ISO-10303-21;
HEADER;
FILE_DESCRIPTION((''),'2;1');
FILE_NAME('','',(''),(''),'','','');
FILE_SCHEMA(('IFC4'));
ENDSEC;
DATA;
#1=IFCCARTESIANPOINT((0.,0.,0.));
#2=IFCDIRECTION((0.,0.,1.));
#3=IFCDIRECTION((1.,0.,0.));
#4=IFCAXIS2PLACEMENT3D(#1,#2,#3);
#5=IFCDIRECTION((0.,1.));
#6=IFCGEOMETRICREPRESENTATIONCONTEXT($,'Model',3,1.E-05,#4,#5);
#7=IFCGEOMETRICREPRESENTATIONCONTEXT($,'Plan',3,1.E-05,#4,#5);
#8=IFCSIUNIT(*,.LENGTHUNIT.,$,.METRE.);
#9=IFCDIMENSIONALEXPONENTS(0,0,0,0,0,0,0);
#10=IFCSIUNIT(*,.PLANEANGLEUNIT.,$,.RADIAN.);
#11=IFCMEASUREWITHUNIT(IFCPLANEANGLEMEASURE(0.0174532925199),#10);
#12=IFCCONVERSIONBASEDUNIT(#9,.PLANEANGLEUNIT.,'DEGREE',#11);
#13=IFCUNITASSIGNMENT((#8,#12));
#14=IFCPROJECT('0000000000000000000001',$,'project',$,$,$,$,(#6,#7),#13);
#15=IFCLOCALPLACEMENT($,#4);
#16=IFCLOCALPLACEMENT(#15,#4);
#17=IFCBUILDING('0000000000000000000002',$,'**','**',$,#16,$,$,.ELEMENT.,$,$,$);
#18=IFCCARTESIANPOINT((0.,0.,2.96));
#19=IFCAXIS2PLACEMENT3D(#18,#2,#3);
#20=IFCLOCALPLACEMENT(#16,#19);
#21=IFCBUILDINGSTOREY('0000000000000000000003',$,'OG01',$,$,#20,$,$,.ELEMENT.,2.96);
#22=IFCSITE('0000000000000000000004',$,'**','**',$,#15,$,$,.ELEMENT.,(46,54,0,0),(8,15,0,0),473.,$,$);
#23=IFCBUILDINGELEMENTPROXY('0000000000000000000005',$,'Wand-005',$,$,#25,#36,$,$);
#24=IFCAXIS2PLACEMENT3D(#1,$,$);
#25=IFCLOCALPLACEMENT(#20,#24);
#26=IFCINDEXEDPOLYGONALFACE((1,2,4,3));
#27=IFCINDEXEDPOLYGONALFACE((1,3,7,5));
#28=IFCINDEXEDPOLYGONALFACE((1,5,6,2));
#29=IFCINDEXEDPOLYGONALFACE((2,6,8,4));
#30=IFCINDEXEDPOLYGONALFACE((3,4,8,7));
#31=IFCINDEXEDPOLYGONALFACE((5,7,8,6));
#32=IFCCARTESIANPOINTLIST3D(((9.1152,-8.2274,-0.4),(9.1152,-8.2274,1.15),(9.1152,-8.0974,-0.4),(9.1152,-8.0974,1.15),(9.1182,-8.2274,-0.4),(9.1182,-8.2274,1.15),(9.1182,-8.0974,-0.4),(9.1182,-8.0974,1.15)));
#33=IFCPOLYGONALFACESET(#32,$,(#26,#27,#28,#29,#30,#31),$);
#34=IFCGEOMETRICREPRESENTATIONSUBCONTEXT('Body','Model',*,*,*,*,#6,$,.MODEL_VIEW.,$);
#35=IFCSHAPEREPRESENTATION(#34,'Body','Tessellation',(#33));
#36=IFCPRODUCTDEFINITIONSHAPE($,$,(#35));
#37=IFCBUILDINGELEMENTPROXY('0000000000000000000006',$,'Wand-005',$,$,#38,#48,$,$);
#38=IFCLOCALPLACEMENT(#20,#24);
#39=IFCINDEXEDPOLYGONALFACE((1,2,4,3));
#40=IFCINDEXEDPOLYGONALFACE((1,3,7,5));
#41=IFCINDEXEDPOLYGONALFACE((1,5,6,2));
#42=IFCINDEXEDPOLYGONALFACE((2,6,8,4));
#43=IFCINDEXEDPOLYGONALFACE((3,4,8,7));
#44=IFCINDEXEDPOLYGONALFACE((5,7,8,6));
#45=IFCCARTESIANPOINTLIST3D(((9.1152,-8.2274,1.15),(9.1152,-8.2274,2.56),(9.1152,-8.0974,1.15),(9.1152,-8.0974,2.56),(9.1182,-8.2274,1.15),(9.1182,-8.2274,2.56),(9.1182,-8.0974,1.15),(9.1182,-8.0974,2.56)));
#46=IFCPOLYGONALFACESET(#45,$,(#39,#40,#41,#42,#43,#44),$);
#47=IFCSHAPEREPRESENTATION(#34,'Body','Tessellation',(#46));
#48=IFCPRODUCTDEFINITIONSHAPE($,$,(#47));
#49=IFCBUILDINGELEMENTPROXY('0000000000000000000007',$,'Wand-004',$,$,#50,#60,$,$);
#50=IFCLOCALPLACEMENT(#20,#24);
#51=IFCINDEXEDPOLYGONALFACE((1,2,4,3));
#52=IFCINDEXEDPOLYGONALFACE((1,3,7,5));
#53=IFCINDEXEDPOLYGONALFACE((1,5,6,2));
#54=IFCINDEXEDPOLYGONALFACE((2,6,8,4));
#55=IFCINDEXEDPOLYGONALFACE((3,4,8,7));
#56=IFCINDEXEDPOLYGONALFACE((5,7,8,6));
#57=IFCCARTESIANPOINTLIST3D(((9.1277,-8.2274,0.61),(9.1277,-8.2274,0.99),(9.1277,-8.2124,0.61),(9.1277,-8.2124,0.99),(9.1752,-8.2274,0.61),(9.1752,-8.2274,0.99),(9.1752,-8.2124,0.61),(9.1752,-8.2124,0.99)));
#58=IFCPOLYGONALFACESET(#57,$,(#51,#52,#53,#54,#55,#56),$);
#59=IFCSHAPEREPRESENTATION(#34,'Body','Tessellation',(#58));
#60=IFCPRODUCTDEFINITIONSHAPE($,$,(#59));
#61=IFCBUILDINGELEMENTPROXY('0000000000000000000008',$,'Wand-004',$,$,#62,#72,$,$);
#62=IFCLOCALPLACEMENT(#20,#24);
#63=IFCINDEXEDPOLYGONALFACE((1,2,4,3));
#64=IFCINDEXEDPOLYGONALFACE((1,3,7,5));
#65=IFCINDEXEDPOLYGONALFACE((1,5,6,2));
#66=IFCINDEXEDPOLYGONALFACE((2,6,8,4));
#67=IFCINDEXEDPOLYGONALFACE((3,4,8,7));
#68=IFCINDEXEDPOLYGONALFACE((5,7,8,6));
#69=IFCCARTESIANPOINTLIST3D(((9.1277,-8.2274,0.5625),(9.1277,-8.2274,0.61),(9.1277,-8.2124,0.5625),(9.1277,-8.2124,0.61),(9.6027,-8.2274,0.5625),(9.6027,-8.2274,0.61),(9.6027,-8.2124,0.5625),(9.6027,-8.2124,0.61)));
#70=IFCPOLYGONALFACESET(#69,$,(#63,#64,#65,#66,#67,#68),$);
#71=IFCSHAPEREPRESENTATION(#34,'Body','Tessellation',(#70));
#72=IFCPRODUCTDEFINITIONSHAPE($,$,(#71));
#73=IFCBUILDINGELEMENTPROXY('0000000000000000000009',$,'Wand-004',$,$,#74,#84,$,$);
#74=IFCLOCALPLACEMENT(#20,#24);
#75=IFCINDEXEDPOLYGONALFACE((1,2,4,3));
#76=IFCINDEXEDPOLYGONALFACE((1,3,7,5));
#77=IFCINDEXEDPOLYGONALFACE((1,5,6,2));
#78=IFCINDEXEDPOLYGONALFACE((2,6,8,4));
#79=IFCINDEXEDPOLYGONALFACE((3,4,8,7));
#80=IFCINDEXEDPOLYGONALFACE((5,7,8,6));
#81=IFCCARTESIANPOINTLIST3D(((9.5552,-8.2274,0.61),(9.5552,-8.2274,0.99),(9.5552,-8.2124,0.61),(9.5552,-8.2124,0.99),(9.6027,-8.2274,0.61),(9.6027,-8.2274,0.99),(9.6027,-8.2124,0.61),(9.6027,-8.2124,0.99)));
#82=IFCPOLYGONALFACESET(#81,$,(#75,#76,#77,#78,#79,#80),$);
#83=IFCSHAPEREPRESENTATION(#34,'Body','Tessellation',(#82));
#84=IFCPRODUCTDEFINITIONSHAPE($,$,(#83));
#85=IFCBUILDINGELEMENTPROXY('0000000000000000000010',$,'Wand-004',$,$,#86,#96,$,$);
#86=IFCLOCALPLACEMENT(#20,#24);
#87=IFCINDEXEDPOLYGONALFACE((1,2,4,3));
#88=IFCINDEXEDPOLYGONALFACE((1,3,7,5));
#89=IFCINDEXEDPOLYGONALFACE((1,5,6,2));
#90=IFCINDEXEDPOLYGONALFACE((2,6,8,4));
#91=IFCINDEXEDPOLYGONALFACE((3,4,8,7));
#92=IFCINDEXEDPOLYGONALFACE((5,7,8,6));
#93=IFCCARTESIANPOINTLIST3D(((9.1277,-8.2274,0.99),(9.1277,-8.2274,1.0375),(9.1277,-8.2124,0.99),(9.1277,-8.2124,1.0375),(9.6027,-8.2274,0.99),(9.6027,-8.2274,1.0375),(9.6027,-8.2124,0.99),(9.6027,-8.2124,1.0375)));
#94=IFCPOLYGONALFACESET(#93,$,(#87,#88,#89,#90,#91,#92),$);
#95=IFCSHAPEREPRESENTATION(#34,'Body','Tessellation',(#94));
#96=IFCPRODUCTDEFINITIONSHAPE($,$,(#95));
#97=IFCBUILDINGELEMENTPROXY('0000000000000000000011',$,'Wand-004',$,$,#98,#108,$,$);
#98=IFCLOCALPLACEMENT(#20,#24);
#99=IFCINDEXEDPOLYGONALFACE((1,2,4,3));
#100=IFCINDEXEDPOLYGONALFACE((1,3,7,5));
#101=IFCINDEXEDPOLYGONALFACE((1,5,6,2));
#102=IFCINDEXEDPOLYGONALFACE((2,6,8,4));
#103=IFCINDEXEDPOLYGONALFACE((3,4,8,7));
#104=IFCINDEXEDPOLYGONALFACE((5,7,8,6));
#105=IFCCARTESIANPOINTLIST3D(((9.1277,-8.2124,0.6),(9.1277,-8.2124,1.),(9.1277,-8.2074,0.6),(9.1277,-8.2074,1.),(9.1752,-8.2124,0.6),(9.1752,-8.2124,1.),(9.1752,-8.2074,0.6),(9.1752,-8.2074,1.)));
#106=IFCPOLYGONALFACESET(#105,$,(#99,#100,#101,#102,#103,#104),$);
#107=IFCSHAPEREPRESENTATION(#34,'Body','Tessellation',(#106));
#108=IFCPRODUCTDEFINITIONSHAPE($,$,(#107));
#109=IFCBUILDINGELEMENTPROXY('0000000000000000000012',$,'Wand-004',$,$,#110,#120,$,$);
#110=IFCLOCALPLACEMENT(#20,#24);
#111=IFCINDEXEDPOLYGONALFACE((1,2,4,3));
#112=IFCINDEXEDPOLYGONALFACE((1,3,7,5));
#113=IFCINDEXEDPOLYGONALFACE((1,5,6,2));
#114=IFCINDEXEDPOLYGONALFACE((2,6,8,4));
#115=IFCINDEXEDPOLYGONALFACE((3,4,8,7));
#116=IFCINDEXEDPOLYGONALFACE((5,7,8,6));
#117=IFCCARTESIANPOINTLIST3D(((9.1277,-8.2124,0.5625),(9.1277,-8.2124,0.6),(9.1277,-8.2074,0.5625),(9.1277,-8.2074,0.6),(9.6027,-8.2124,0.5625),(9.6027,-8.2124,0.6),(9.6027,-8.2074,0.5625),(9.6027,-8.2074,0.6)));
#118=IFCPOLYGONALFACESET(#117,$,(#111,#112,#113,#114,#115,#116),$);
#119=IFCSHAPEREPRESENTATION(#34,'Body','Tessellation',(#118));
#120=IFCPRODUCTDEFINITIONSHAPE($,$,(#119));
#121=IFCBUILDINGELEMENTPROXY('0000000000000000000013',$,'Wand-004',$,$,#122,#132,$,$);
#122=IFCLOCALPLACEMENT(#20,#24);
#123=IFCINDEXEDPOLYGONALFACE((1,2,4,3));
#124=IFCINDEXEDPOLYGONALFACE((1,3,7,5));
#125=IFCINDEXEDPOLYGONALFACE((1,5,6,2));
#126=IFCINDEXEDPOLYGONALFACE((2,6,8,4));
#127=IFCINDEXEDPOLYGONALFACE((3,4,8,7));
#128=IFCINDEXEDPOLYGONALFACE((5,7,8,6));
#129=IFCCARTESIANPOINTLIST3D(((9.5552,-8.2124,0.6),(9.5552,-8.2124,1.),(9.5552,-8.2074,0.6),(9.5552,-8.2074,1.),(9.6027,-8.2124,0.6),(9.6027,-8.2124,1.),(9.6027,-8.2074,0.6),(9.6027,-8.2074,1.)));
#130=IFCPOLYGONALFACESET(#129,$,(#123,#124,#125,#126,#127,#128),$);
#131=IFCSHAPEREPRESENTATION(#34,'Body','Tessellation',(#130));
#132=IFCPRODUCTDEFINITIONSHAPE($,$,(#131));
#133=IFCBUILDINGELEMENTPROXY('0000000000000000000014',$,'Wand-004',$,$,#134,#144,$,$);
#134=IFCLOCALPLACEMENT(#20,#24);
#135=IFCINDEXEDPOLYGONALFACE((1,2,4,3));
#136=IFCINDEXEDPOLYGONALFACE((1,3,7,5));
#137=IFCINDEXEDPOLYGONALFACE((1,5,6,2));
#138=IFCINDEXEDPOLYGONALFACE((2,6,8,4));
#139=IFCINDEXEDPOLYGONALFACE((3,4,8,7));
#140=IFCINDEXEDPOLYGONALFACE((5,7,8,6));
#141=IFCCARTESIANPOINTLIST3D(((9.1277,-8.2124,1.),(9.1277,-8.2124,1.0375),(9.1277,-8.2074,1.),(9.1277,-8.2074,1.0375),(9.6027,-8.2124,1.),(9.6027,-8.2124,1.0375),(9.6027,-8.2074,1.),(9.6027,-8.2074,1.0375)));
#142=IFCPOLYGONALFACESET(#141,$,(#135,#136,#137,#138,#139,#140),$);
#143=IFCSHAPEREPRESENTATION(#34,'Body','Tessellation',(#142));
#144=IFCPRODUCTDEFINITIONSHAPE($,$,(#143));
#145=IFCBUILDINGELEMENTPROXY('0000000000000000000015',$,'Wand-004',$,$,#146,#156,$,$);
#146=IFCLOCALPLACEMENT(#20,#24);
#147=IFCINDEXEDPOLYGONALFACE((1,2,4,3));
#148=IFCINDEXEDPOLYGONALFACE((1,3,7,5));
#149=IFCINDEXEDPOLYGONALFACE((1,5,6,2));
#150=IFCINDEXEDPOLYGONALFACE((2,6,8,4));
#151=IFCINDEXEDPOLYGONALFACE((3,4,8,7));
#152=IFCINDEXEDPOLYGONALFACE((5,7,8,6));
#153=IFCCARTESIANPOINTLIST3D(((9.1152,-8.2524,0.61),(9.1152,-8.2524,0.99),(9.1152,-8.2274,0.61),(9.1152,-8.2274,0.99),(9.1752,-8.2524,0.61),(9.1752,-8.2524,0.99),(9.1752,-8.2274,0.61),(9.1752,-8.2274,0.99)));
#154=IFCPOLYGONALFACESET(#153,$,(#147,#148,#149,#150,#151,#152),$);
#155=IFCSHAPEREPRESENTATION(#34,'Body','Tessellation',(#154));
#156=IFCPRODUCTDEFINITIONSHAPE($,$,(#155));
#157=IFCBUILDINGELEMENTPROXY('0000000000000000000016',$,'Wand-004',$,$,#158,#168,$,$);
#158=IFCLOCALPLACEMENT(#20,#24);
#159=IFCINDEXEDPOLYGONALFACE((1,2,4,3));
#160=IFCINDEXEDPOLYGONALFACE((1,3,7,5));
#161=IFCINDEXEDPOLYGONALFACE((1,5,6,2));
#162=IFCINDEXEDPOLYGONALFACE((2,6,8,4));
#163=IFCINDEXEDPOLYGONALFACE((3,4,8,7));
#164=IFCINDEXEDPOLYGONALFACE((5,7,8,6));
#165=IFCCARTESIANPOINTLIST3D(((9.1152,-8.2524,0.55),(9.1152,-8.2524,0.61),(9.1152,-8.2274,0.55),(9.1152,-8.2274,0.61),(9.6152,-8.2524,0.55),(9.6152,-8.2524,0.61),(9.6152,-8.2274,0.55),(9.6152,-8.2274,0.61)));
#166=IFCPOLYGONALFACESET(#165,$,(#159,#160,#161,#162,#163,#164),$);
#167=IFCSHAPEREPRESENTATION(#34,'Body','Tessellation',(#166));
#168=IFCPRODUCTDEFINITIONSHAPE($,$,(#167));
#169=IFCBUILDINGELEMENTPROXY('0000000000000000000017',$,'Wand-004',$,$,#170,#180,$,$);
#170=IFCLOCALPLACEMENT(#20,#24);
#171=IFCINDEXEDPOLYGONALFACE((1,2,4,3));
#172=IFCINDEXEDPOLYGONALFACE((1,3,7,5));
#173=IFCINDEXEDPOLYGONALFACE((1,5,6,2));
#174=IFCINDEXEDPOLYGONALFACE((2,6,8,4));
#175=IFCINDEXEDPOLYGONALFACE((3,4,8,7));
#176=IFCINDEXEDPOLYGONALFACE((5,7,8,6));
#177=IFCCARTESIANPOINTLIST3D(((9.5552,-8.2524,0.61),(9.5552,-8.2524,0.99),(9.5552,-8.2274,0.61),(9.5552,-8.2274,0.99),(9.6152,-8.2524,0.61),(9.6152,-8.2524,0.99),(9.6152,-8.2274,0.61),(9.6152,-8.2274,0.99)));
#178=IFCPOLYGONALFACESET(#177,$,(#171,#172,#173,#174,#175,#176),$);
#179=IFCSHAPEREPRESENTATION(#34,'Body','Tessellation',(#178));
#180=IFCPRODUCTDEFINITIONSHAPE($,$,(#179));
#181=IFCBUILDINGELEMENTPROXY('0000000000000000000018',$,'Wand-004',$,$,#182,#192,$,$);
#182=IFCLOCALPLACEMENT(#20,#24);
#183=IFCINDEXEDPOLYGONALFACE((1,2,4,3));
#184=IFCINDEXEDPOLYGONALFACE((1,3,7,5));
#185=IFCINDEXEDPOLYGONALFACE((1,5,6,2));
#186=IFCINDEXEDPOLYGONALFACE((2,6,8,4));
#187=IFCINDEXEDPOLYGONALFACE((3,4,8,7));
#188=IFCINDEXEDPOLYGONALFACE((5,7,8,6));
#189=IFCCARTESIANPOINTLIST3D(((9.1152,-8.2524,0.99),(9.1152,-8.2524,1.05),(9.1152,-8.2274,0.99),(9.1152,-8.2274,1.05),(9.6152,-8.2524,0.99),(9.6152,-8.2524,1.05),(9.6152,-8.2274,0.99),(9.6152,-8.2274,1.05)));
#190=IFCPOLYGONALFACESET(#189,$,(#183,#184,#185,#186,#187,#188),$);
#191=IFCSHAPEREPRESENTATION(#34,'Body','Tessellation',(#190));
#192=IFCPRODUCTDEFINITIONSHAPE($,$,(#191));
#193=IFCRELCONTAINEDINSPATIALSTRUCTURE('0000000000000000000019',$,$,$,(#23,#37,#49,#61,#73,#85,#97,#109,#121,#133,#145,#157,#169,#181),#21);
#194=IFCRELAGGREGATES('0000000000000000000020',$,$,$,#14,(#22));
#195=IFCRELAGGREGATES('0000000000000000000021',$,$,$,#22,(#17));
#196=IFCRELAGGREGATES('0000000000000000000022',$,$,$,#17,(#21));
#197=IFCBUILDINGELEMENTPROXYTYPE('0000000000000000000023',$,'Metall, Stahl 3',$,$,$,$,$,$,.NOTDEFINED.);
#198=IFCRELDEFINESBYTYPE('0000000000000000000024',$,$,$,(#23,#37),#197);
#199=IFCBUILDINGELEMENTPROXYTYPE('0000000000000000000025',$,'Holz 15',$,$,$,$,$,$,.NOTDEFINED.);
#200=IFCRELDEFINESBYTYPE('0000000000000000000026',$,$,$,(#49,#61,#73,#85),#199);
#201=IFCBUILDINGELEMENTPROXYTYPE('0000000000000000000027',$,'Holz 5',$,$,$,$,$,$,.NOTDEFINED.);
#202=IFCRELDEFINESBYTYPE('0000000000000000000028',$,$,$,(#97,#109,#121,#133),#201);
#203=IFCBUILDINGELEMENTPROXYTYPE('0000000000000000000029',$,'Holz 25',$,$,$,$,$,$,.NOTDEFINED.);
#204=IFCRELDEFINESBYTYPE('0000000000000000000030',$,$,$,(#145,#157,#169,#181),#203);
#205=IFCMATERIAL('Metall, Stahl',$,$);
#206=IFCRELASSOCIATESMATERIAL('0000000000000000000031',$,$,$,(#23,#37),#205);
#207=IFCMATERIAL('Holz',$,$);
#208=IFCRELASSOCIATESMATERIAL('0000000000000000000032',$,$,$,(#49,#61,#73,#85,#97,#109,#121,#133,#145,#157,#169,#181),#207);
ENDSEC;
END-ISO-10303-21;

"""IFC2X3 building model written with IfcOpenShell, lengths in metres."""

from ifc_helpers import new_model, entity, si_unit, converted_unit, direction, frame, origin_with_axes, place, context, subcontext, project, spatial, polyline, outline, extrude, material, type_object, element, save


model = new_model("IFC2X3")

# Units and contexts
model_context = context("Model", 3, precision=1e-05, world=origin_with_axes(), true_north=direction((0.0, 1.0)))
plan_context = context("Plan", 3, precision=1e-05, world=origin_with_axes(), true_north=direction((0.0, 1.0)))
body_context = subcontext(model_context, "Body", "Model", "MODEL_VIEW")
ifc_project = project(units=[si_unit("LENGTHUNIT", "METRE"), converted_unit("PLANEANGLEUNIT", "DEGREE", entity("IfcPlaneAngleMeasure", 0.0174532925199), si_unit("PLANEANGLEUNIT", "RADIAN"), dimensions=[0, 0, 0, 0, 0, 0, 0])], contexts=[model_context, plan_context])

# Site, building, storey
site_placement = place(None, origin_with_axes())
site = spatial("IfcSite", under=ifc_project, at=site_placement, Name="**", Description="**", CompositionType="ELEMENT", RefLatitude=(46, 54, 0, 0), RefLongitude=(8, 15, 0, 0), RefElevation=473.0)
building_placement = place(site_placement, origin_with_axes())
building = spatial("IfcBuilding", under=site, at=building_placement, Name="**", Description="**", CompositionType="ELEMENT")
storey_placement = place(building_placement, frame((0.0, 0.0, 2.96), z_axis=(0.0, 0.0, 1.0), x_axis=(1.0, 0.0, 0.0)))
storey = spatial("IfcBuildingStorey", under=building, at=storey_placement, Name="OG01", CompositionType="ELEMENT", Elevation=2.96)

# Building element proxies
ifc_material_1 = material(Name="Metall, Stahl")
building_element_proxy_type_1 = type_object("IfcBuildingElementProxyType", Name="Metall, Stahl 3", PredefinedType="NOTDEFINED")
proxy_1_placement = place(storey_placement, frame((9.1152, -8.0974, -0.4), z_axis=(0.0, 0.0, 1.0), x_axis=(0.0, -1.0, 0.0)))
element("IfcBuildingElementProxy", 1, at=proxy_1_placement, inside=storey, type_object=building_element_proxy_type_1, material=ifc_material_1, Name="Wand-005", context=body_context, shape_type="SweptSolid", body=[
    extrude(outline(polyline([(0.0, 0.0), (0.13, 0.0), (0.13, 0.003), (0.0, 0.003), (0.0, 0.0)])), origin_with_axes(), (0.0, 0.0, 1.0), 1.55),
])
proxy_2_placement = place(storey_placement, frame((9.1152, -8.0974, 1.15), z_axis=(0.0, 0.0, 1.0), x_axis=(0.0, -1.0, 0.0)))
element("IfcBuildingElementProxy", 2, at=proxy_2_placement, inside=storey, type_object=building_element_proxy_type_1, material=ifc_material_1, Name="Wand-005", context=body_context, shape_type="SweptSolid", body=[
    extrude(outline(polyline([(0.0, 0.0), (0.13, 0.0), (0.13, 0.003), (0.0, 0.003), (0.0, 0.0)])), origin_with_axes(), (0.0, 0.0, 1.0), 1.41),
])
ifc_material_2 = material(Name="Holz")
building_element_proxy_type_2 = type_object("IfcBuildingElementProxyType", Name="Holz 15", PredefinedType="NOTDEFINED")
proxy_3_placement = place(storey_placement, frame((9.1277, -8.2274, 0.61), z_axis=(0.0, 0.0, 1.0), x_axis=(1.0, 0.0, 0.0)))
element("IfcBuildingElementProxy", 3, at=proxy_3_placement, inside=storey, type_object=building_element_proxy_type_2, material=ifc_material_2, Name="Wand-004", context=body_context, shape_type="SweptSolid", body=[
    extrude(outline(polyline([(0.0, 0.0), (0.0475, 0.0), (0.0475, 0.015), (0.0, 0.015), (0.0, 0.0)])), origin_with_axes(), (0.0, 0.0, 1.0), 0.38),
])
proxy_4_placement = place(storey_placement, frame((9.6027, -8.2124, 0.5625), z_axis=(0.0, 0.0, 1.0), x_axis=(-1.0, 0.0, 0.0)))
element("IfcBuildingElementProxy", 4, at=proxy_4_placement, inside=storey, type_object=building_element_proxy_type_2, material=ifc_material_2, Name="Wand-004", context=body_context, shape_type="SweptSolid", body=[
    extrude(outline(polyline([(0.0, 0.0), (0.475, 0.0), (0.475, 0.015), (0.0, 0.015), (0.0, 0.0)])), origin_with_axes(), (0.0, 0.0, 1.0), 0.0475),
])
proxy_5_placement = place(storey_placement, frame((9.5552, -8.2274, 0.61), z_axis=(0.0, 0.0, 1.0), x_axis=(1.0, 0.0, 0.0)))
element("IfcBuildingElementProxy", 5, at=proxy_5_placement, inside=storey, type_object=building_element_proxy_type_2, material=ifc_material_2, Name="Wand-004", context=body_context, shape_type="SweptSolid", body=[
    extrude(outline(polyline([(0.0, 0.0), (0.0475, 0.0), (0.0475, 0.015), (0.0, 0.015), (0.0, 0.0)])), origin_with_axes(), (0.0, 0.0, 1.0), 0.38),
])
proxy_6_placement = place(storey_placement, frame((9.6027, -8.2124, 0.99), z_axis=(0.0, 0.0, 1.0), x_axis=(-1.0, 0.0, 0.0)))
element("IfcBuildingElementProxy", 6, at=proxy_6_placement, inside=storey, type_object=building_element_proxy_type_2, material=ifc_material_2, Name="Wand-004", context=body_context, shape_type="SweptSolid", body=[
    extrude(outline(polyline([(0.0, 0.0), (0.475, 0.0), (0.475, 0.015), (0.0, 0.015), (0.0, 0.0)])), origin_with_axes(), (0.0, 0.0, 1.0), 0.0475),
])
building_element_proxy_type_3 = type_object("IfcBuildingElementProxyType", Name="Holz 5", PredefinedType="NOTDEFINED")
proxy_7_placement = place(storey_placement, frame((9.1277, -8.2124, 0.6), z_axis=(0.0, 0.0, 1.0), x_axis=(1.0, 0.0, 0.0)))
element("IfcBuildingElementProxy", 7, at=proxy_7_placement, inside=storey, type_object=building_element_proxy_type_3, material=ifc_material_2, Name="Wand-004", context=body_context, shape_type="SweptSolid", body=[
    extrude(outline(polyline([(0.0, 0.0), (0.0475, 0.0), (0.0475, 0.005), (0.0, 0.005), (0.0, 0.0)])), origin_with_axes(), (0.0, 0.0, 1.0), 0.4),
])
proxy_8_placement = place(storey_placement, frame((9.6027, -8.2124, 0.5625), z_axis=(0.0, 0.0, 1.0), x_axis=(-1.0, 0.0, 0.0)))
element("IfcBuildingElementProxy", 8, at=proxy_8_placement, inside=storey, type_object=building_element_proxy_type_3, material=ifc_material_2, Name="Wand-004", context=body_context, shape_type="SweptSolid", body=[
    extrude(outline(polyline([(0.0, -0.005), (0.475, -0.005), (0.475, 0.0), (0.0, 0.0), (0.0, -0.005)])), origin_with_axes(), (0.0, 0.0, 1.0), 0.0375),
])
proxy_9_placement = place(storey_placement, frame((9.5552, -8.2124, 0.6), z_axis=(0.0, 0.0, 1.0), x_axis=(1.0, 0.0, 0.0)))
element("IfcBuildingElementProxy", 9, at=proxy_9_placement, inside=storey, type_object=building_element_proxy_type_3, material=ifc_material_2, Name="Wand-004", context=body_context, shape_type="SweptSolid", body=[
    extrude(outline(polyline([(0.0, 0.0), (0.0475, 0.0), (0.0475, 0.005), (0.0, 0.005), (0.0, 0.0)])), origin_with_axes(), (0.0, 0.0, 1.0), 0.4),
])
proxy_10_placement = place(storey_placement, frame((9.6027, -8.2124, 1.0), z_axis=(0.0, 0.0, 1.0), x_axis=(-1.0, 0.0, 0.0)))
element("IfcBuildingElementProxy", 10, at=proxy_10_placement, inside=storey, type_object=building_element_proxy_type_3, material=ifc_material_2, Name="Wand-004", context=body_context, shape_type="SweptSolid", body=[
    extrude(outline(polyline([(0.0, -0.005), (0.475, -0.005), (0.475, 0.0), (0.0, 0.0), (0.0, -0.005)])), origin_with_axes(), (0.0, 0.0, 1.0), 0.0375),
])
building_element_proxy_type_4 = type_object("IfcBuildingElementProxyType", Name="Holz 25", PredefinedType="NOTDEFINED")
proxy_11_placement = place(storey_placement, frame((9.1152, -8.2524, 0.61), z_axis=(0.0, 0.0, 1.0), x_axis=(1.0, 0.0, 0.0)))
element("IfcBuildingElementProxy", 11, at=proxy_11_placement, inside=storey, type_object=building_element_proxy_type_4, material=ifc_material_2, Name="Wand-004", context=body_context, shape_type="SweptSolid", body=[
    extrude(outline(polyline([(0.0, 0.0), (0.06, 0.0), (0.06, 0.025), (0.0, 0.025), (0.0, 0.0)])), origin_with_axes(), (0.0, 0.0, 1.0), 0.38),
])
proxy_12_placement = place(storey_placement, frame((9.6152, -8.2274, 0.55), z_axis=(0.0, 0.0, 1.0), x_axis=(-1.0, 0.0, 0.0)))
element("IfcBuildingElementProxy", 12, at=proxy_12_placement, inside=storey, type_object=building_element_proxy_type_4, material=ifc_material_2, Name="Wand-004", context=body_context, shape_type="SweptSolid", body=[
    extrude(outline(polyline([(0.0, 0.0), (0.5, 0.0), (0.5, 0.025), (0.0, 0.025), (0.0, 0.0)])), origin_with_axes(), (0.0, 0.0, 1.0), 0.06),
])
proxy_13_placement = place(storey_placement, frame((9.5552, -8.2524, 0.61), z_axis=(0.0, 0.0, 1.0), x_axis=(1.0, 0.0, 0.0)))
element("IfcBuildingElementProxy", 13, at=proxy_13_placement, inside=storey, type_object=building_element_proxy_type_4, material=ifc_material_2, Name="Wand-004", context=body_context, shape_type="SweptSolid", body=[
    extrude(outline(polyline([(0.0, 0.0), (0.06, 0.0), (0.06, 0.025), (0.0, 0.025), (0.0, 0.0)])), origin_with_axes(), (0.0, 0.0, 1.0), 0.38),
])
proxy_14_placement = place(storey_placement, frame((9.6152, -8.2274, 0.99), z_axis=(0.0, 0.0, 1.0), x_axis=(-1.0, 0.0, 0.0)))
element("IfcBuildingElementProxy", 14, at=proxy_14_placement, inside=storey, type_object=building_element_proxy_type_4, material=ifc_material_2, Name="Wand-004", context=body_context, shape_type="SweptSolid", body=[
    extrude(outline(polyline([(0.0, 0.0), (0.5, 0.0), (0.5, 0.025), (0.0, 0.025), (0.0, 0.0)])), origin_with_axes(), (0.0, 0.0, 1.0), 0.06),
])

save(model, "model.ifc")
